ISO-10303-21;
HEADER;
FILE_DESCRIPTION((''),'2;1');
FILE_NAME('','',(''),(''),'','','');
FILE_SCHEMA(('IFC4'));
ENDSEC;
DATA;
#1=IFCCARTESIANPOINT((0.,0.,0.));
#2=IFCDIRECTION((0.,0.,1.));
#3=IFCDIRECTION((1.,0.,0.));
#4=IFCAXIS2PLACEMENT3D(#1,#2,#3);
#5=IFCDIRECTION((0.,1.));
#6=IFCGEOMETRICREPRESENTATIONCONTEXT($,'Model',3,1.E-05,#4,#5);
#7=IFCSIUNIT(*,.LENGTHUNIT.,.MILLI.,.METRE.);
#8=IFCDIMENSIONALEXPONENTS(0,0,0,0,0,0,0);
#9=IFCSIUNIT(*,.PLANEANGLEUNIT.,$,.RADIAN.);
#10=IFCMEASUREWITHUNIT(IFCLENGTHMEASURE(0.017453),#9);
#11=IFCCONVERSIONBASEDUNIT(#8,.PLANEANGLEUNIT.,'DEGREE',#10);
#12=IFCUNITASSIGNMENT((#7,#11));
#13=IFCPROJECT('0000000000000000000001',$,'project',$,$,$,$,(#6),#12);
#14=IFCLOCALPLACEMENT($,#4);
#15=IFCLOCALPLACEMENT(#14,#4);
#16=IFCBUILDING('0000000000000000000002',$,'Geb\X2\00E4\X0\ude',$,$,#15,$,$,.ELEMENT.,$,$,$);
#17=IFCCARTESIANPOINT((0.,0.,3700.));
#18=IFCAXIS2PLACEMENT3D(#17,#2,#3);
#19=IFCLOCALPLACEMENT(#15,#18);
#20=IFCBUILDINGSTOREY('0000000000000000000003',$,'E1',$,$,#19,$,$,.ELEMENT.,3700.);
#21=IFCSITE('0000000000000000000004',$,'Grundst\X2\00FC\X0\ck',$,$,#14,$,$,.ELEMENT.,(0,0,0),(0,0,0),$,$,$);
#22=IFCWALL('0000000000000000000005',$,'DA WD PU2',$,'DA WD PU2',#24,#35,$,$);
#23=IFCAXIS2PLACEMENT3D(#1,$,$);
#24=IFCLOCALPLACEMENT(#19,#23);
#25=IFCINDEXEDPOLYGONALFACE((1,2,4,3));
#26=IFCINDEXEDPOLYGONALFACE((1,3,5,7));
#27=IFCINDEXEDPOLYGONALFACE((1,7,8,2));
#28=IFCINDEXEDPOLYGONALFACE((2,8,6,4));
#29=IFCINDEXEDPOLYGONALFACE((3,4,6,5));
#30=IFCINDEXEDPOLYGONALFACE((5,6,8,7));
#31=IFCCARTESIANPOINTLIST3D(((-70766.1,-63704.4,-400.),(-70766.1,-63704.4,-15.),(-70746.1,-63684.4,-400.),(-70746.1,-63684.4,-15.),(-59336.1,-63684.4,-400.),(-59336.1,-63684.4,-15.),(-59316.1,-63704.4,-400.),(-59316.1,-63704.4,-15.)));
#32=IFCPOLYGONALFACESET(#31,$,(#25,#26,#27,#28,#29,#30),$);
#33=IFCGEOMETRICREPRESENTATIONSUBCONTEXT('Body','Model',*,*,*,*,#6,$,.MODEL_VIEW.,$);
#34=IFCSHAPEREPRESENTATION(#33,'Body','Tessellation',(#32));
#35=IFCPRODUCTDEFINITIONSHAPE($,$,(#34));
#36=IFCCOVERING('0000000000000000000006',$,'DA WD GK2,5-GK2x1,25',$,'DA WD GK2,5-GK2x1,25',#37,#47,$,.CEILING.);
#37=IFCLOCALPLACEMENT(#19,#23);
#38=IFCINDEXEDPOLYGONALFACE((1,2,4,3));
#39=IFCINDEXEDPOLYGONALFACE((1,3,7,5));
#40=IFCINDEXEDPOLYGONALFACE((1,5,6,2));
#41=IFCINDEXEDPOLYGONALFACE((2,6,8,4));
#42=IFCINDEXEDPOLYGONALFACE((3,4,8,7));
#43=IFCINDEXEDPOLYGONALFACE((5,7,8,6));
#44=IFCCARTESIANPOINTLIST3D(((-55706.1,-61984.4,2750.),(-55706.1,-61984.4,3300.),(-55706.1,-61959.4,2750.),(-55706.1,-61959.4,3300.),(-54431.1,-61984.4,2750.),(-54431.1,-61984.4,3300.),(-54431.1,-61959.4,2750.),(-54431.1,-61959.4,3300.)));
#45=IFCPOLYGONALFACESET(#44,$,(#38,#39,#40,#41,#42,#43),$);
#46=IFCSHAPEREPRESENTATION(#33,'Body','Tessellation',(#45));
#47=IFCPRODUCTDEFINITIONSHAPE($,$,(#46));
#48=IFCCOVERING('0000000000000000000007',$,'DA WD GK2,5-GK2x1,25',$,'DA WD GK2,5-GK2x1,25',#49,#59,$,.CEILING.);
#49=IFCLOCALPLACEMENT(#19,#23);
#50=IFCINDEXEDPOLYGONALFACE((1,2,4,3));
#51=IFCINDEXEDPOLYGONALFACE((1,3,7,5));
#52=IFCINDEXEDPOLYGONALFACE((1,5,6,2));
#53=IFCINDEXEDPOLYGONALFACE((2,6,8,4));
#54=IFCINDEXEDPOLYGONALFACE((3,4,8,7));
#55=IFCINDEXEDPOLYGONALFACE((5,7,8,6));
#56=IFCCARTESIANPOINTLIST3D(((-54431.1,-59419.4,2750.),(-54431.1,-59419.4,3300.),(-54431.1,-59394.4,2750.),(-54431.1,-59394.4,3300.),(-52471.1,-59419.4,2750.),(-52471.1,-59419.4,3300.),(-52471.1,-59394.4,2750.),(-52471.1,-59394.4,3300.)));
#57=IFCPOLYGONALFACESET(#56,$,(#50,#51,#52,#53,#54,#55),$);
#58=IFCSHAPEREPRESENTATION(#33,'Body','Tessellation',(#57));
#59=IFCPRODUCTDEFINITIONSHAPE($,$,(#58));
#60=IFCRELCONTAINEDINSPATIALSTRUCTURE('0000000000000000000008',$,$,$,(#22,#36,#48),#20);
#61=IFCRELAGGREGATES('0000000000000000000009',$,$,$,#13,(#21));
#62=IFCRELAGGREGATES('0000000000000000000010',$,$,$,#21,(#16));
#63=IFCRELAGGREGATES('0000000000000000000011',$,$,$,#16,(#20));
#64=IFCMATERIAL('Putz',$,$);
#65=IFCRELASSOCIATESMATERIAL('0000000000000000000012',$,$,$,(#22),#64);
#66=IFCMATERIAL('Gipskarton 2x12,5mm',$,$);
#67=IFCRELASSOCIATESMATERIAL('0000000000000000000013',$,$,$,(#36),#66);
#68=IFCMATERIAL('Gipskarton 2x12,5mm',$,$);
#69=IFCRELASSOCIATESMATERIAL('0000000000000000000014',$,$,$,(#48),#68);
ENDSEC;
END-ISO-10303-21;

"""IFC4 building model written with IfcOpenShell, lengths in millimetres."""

from ifc_helpers import new_model, entity, si_unit, converted_unit, direction, frame, origin_with_axes, place, context, subcontext, project, spatial, line, indexed_curve, outline, extrude, material, element, save


model = new_model("IFC4")

# Units and contexts
model_context = context("Model", 3, precision=1e-05, world=origin_with_axes(), true_north=direction((0.0, 1.0)))
body_context = subcontext(model_context, "Body", "Model", "MODEL_VIEW")
ifc_project = project(units=[si_unit("LENGTHUNIT", "METRE", prefix="MILLI"), converted_unit("PLANEANGLEUNIT", "DEGREE", entity("IfcLengthMeasure", 0.017453), si_unit("PLANEANGLEUNIT", "RADIAN"), dimensions=[0, 0, 0, 0, 0, 0, 0])], contexts=[model_context])

# Site, building, storey
site_placement = place(None, origin_with_axes())
site = spatial("IfcSite", under=ifc_project, at=site_placement, Name="Grundstück", CompositionType="ELEMENT", RefLatitude=(0, 0, 0), RefLongitude=(0, 0, 0))
building_placement = place(site_placement, origin_with_axes())
building = spatial("IfcBuilding", under=site, at=building_placement, Name="Gebäude", CompositionType="ELEMENT")
storey_placement = place(building_placement, frame((0.0, 0.0, 3700.0), z_axis=(0.0, 0.0, 1.0), x_axis=(1.0, 0.0, 0.0)))
storey = spatial("IfcBuildingStorey", under=building, at=storey_placement, Name="E1", CompositionType="ELEMENT", Elevation=3700.0)

# Wall
ifc_material_1 = material(Name="Putz")
wall_1_placement = place(storey_placement, frame((-59326.1, -63694.4, -400.0), z_axis=(0.0, 0.0, 1.0), x_axis=(-1.0, 0.0, 0.0)))
element("IfcWall", 1, at=wall_1_placement, inside=storey, material=ifc_material_1, Name="DA WD PU2", ObjectType="DA WD PU2", context=body_context, shape_type="SweptSolid", body=[
    extrude(outline(indexed_curve([(10.0, -10.0), (-10.0, 10.0), (11440.0, 10.0), (11420.0, -10.0)], segments=[line(1, 2), line(2, 3), line(3, 4), line(4, 1)])), origin_with_axes(), (0.0, 0.0, 1.0), 385.0),
])

# Coverings
ifc_material_2 = material(Name="Gipskarton 2x12,5mm")
covering_1_placement = place(storey_placement, frame((-54431.1, -61971.9, 2750.0), z_axis=(0.0, 0.0, 1.0), x_axis=(-1.0, 0.0, 0.0)))
element("IfcCovering", 2, at=covering_1_placement, inside=storey, material=ifc_material_2, Name="DA WD GK2,5-GK2x1,25", ObjectType="DA WD GK2,5-GK2x1,25", PredefinedType="CEILING", context=body_context, shape_type="SweptSolid", body=[
    extrude(outline(indexed_curve([(0.0, -12.5), (0.0, 12.5), (1275.0, 12.5), (1275.0, -12.5)], segments=[line(1, 2), line(2, 3), line(3, 4), line(4, 1)])), origin_with_axes(), (0.0, 0.0, 1.0), 550.0),
])
ifc_material_3 = material(Name="Gipskarton 2x12,5mm")
covering_2_placement = place(storey_placement, frame((-54431.1, -59406.9, 2750.0), z_axis=(0.0, 0.0, 1.0), x_axis=(1.0, 0.0, 0.0)))
element("IfcCovering", 3, at=covering_2_placement, inside=storey, material=ifc_material_3, Name="DA WD GK2,5-GK2x1,25", ObjectType="DA WD GK2,5-GK2x1,25", PredefinedType="CEILING", context=body_context, shape_type="SweptSolid", body=[
    extrude(outline(indexed_curve([(0.0, -12.5), (0.0, 12.5), (1960.0, 12.5), (1960.0, -12.5)], segments=[line(1, 2), line(2, 3), line(3, 4), line(4, 1)])), origin_with_axes(), (0.0, 0.0, 1.0), 550.0),
])

save(model, "model.ifc")
